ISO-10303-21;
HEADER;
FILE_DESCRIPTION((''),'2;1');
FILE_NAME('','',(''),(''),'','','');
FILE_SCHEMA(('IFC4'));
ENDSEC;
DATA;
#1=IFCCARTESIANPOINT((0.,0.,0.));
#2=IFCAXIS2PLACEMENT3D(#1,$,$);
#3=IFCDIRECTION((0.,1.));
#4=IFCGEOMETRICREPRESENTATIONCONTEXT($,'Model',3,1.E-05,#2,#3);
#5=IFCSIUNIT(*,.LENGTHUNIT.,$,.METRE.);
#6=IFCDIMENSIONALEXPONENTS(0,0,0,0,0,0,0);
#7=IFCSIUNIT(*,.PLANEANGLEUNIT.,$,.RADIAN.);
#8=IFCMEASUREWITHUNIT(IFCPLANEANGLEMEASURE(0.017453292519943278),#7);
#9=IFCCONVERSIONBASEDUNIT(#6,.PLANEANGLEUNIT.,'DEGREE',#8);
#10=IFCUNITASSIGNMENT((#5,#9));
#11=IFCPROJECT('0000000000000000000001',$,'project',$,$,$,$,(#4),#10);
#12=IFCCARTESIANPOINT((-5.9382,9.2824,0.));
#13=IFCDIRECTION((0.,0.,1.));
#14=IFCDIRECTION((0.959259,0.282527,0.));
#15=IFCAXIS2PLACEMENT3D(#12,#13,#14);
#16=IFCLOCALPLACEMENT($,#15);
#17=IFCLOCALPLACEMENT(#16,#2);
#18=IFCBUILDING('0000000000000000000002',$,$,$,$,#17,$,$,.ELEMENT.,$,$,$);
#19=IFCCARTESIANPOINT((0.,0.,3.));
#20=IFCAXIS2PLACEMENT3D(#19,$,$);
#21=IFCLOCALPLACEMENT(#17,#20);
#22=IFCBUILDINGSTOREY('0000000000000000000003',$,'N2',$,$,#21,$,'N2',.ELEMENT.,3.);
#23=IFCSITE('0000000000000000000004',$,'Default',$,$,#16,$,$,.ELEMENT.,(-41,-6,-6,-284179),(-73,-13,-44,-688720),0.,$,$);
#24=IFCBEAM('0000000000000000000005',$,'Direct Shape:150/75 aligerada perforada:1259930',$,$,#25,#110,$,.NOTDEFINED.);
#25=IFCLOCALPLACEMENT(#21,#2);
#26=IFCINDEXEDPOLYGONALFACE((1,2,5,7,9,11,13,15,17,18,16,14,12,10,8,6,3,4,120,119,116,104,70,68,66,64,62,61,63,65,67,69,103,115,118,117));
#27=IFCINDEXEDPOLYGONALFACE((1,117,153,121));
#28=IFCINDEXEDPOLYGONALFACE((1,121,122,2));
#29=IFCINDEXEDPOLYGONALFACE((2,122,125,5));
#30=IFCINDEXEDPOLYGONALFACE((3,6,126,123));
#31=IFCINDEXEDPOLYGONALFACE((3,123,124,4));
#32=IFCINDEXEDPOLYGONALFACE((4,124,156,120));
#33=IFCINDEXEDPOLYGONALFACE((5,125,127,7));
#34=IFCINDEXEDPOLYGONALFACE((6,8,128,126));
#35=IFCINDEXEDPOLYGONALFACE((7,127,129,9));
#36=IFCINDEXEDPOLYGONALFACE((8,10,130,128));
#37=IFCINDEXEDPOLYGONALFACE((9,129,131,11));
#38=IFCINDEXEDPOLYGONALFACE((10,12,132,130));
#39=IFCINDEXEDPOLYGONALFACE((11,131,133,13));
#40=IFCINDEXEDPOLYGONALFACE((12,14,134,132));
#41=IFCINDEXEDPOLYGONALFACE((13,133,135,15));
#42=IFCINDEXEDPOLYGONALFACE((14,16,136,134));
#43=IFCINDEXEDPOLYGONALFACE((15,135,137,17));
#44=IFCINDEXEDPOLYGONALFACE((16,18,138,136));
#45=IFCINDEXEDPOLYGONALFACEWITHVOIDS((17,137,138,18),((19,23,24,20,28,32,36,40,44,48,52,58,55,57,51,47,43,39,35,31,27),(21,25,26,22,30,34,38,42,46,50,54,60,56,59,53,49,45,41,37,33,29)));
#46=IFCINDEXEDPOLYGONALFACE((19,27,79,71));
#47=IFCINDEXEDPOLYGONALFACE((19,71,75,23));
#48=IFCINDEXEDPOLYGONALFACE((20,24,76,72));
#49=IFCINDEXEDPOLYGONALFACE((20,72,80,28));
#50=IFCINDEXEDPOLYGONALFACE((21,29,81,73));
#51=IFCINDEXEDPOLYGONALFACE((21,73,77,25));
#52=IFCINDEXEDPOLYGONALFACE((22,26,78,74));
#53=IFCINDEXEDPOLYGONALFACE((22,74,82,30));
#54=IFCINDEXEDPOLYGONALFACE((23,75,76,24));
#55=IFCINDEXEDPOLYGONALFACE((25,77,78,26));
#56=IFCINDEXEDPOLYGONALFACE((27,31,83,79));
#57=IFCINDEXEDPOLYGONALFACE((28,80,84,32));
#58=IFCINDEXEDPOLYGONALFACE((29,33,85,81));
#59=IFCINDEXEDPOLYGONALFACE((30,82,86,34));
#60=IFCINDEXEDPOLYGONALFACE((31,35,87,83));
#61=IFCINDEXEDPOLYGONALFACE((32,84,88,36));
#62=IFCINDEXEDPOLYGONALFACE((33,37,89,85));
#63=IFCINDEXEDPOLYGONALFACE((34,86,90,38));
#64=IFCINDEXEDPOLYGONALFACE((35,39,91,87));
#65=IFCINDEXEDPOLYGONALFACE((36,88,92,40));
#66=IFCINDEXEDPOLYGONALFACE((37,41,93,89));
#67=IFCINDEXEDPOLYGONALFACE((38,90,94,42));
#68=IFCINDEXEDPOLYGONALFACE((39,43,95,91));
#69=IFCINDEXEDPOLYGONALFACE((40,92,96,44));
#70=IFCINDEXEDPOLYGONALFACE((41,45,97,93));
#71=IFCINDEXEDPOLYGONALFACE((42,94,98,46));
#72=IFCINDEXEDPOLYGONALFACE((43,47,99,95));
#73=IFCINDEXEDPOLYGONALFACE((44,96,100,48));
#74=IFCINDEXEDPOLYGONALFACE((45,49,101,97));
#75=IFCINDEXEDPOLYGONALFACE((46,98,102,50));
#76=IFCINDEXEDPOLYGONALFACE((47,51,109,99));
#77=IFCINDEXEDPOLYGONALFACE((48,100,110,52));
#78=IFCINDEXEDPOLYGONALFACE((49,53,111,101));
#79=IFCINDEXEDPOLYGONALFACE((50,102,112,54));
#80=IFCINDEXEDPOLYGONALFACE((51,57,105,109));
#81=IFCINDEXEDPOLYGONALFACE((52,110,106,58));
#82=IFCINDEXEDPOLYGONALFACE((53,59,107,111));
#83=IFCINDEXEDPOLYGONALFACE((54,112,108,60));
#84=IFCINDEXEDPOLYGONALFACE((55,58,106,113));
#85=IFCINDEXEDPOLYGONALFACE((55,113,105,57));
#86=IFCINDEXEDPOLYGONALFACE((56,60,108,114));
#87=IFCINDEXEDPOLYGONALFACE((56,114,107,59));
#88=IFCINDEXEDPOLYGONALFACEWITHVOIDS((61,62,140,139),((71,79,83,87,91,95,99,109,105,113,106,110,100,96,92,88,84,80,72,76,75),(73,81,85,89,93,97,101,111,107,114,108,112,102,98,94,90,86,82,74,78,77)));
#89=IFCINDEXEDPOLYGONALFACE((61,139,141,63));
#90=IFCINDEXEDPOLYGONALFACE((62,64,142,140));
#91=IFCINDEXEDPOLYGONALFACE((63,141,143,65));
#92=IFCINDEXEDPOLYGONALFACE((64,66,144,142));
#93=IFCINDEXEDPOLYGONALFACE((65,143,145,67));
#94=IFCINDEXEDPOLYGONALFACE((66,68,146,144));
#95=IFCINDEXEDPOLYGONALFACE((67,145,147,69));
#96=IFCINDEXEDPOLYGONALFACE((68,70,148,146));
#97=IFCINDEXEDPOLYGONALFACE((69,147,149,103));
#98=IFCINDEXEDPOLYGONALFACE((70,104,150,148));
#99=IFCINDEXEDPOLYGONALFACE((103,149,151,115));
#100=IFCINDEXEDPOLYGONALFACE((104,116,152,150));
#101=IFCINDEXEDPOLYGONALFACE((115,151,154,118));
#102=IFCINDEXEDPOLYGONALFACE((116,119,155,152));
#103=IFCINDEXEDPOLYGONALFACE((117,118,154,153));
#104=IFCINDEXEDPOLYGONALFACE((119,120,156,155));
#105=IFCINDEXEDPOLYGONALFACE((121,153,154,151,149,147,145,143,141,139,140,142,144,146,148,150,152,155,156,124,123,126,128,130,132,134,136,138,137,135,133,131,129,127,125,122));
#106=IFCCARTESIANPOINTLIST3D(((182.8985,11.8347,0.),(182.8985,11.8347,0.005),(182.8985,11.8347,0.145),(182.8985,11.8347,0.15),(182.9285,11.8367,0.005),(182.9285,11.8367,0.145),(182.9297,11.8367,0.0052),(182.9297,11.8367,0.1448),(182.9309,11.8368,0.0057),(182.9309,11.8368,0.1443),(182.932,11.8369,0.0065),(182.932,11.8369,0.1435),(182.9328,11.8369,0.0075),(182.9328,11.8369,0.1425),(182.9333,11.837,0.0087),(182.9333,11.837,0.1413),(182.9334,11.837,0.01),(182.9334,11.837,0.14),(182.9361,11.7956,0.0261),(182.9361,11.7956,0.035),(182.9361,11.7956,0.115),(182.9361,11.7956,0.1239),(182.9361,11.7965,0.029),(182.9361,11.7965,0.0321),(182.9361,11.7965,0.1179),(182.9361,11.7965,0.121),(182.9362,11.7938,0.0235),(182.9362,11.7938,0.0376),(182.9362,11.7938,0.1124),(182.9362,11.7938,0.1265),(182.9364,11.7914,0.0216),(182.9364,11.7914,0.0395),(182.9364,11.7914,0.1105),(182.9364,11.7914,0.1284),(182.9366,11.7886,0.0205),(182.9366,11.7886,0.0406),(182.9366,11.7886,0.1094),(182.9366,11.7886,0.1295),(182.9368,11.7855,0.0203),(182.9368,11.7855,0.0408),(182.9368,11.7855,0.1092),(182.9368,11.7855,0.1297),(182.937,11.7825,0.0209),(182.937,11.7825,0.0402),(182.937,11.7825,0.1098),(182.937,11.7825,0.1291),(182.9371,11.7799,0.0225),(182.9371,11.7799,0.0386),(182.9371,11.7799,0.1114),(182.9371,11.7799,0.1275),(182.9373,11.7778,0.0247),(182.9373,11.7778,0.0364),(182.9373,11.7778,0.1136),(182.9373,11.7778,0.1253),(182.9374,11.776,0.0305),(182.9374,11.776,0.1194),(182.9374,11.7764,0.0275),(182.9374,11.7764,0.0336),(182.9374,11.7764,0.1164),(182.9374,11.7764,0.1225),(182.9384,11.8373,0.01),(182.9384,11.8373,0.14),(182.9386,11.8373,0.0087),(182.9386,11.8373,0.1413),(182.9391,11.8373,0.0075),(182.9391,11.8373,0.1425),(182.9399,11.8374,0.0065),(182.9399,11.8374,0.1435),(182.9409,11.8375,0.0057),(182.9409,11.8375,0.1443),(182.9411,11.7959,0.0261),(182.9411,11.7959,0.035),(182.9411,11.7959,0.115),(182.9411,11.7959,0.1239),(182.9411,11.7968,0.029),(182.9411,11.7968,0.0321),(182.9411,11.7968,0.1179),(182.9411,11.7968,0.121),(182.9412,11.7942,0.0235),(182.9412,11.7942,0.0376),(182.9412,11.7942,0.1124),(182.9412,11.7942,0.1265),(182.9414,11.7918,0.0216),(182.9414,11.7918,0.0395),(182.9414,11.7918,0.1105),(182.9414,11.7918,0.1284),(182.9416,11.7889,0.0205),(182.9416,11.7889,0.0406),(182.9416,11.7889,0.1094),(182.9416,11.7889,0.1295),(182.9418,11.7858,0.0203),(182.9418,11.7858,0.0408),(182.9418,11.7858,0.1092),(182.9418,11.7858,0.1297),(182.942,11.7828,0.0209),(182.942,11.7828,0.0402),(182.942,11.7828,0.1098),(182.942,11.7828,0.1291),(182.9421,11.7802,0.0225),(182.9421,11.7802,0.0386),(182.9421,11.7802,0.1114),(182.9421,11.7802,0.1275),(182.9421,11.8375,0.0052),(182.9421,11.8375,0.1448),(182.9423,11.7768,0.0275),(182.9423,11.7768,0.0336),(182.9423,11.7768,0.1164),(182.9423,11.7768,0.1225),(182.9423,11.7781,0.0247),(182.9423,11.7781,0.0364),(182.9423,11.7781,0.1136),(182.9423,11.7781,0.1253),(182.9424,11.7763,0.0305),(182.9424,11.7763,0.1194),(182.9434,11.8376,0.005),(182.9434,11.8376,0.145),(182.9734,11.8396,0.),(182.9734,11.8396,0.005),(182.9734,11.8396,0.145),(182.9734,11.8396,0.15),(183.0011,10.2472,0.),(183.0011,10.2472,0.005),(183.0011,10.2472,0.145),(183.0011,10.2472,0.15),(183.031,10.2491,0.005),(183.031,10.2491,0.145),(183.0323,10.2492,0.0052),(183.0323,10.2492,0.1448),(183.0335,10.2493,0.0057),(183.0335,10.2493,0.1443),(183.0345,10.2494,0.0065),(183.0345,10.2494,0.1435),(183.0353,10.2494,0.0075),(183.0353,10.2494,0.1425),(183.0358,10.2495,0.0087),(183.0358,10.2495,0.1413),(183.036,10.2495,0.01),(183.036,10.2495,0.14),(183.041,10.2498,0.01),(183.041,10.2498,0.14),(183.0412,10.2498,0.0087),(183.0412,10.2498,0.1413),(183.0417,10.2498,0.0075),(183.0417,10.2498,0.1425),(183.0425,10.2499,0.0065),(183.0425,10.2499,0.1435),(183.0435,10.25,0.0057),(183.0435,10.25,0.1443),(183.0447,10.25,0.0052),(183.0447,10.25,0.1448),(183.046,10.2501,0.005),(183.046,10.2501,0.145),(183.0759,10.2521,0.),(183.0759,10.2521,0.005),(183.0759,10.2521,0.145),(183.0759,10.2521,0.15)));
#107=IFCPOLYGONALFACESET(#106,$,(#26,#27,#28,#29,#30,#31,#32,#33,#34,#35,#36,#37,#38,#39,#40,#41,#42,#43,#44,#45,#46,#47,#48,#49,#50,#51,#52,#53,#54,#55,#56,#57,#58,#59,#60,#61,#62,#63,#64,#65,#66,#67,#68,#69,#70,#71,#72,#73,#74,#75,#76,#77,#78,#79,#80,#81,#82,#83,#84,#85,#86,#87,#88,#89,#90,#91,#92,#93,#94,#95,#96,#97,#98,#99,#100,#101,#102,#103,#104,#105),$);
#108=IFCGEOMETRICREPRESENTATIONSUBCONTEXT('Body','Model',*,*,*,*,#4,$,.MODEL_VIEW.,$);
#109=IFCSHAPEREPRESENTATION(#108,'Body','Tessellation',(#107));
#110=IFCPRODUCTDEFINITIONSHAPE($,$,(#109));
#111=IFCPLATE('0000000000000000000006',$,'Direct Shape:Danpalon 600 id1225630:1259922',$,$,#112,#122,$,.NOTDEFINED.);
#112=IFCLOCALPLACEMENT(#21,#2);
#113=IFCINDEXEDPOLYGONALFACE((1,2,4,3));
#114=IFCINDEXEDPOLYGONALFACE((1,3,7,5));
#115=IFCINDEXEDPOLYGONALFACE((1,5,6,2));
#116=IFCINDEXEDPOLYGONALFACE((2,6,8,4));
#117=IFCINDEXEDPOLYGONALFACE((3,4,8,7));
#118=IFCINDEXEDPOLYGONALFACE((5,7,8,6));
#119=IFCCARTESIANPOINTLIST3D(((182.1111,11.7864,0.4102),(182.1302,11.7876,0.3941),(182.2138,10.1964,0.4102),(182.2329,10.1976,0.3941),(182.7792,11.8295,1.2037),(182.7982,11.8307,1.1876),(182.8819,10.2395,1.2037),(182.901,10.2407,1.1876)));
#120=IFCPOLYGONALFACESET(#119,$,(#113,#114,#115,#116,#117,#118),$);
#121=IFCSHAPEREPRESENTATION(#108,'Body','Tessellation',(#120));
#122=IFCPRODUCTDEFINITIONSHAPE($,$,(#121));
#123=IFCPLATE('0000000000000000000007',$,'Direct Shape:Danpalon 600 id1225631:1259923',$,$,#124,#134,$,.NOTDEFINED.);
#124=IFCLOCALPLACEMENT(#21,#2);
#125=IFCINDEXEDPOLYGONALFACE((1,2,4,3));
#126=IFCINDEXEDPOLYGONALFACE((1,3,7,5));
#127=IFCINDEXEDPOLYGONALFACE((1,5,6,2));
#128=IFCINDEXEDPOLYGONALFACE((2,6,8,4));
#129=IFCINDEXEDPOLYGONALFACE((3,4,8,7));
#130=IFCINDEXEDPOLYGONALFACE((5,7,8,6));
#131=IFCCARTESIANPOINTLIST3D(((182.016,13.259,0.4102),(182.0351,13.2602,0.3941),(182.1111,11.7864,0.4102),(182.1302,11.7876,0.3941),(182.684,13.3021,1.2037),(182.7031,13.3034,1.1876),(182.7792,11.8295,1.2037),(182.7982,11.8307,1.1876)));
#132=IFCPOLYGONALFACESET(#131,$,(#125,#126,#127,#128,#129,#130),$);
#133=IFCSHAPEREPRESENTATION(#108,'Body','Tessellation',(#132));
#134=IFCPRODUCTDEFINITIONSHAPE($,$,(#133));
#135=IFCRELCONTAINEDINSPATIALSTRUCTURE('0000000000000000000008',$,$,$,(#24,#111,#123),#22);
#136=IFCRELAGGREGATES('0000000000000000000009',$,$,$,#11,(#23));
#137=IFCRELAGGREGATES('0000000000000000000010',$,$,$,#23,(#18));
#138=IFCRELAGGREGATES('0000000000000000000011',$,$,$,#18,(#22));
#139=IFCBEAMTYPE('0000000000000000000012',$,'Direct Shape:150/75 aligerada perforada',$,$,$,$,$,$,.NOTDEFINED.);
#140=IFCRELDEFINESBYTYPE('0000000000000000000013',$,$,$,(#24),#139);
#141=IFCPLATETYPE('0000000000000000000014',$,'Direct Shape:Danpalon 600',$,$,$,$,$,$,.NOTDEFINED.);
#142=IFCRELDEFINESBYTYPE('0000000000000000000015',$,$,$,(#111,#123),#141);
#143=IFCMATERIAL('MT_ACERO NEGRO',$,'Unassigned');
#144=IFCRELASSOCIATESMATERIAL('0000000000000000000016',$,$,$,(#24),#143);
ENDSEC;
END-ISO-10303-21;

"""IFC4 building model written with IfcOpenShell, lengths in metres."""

from ifc_helpers import new_model, entity, si_unit, converted_unit, direction, frame, frame_2d, origin, place, context, subcontext, project, spatial, rectangle, circle, i_section, extrude, material, type_object, element, save


model = new_model("IFC4")

# Units and contexts
model_context = context("Model", 3, precision=1e-05, world=origin(), true_north=direction((0.0, 1.0)))
body_context = subcontext(model_context, "Body", "Model", "MODEL_VIEW")
ifc_project = project(units=[si_unit("LENGTHUNIT", "METRE"), converted_unit("PLANEANGLEUNIT", "DEGREE", entity("IfcPlaneAngleMeasure", 0.017453292519943278), si_unit("PLANEANGLEUNIT", "RADIAN"), dimensions=[0, 0, 0, 0, 0, 0, 0])], contexts=[model_context])

# Site, building, storey
site_placement = place(None, frame((-5.9382, 9.2824, 0.0), z_axis=(0.0, 0.0, 1.0), x_axis=(0.959259, 0.282527, 0.0)))
site = spatial("IfcSite", under=ifc_project, at=site_placement, Name="Default", CompositionType="ELEMENT", RefLatitude=(-41, -6, -6, -284179), RefLongitude=(-73, -13, -44, -688720), RefElevation=0.0)
building_placement = place(site_placement, origin())
building = spatial("IfcBuilding", under=site, at=building_placement, CompositionType="ELEMENT")
storey_placement = place(building_placement, frame((0.0, 0.0, 3.0)))
storey = spatial("IfcBuildingStorey", under=building, at=storey_placement, Name="N2", LongName="N2", CompositionType="ELEMENT", Elevation=3.0)

# Beam, openings
ifc_material = material(Name="MT_ACERO NEGRO", Category="Unassigned")
beam_type = type_object("IfcBeamType", Name="Direct Shape:150/75 aligerada perforada", PredefinedType="NOTDEFINED")
beam_placement = place(storey_placement, origin())
beam = element("IfcBeam", 1, at=beam_placement, inside=storey, type_object=beam_type, material=ifc_material, Name="Direct Shape:150/75 aligerada perforada:1259930", PredefinedType="NOTDEFINED", context=body_context, shape_type="SweptSolid", body=[
    extrude(i_section(OverallWidth=0.075, OverallDepth=0.15, WebThickness=0.005, FlangeThickness=0.005, FilletRadius=0.005, at=frame_2d((0.0, 0.0), x_axis=(0.0, 1.0))), frame((183.0385, 10.2496, 0.075), z_axis=(-0.064471, 0.99792, 0.0), x_axis=(0.0, 0.0, 1.0)), (0.0, 0.0, 1.0), 1.5908),
])
opening_1_placement = place(storey_placement, origin())
element("IfcOpeningElement", 2, at=opening_1_placement, cuts=beam, PredefinedType="OPENING", context=body_context, shape_type="SweptSolid", body=[
    extrude(circle(Radius=0.0103, at=frame_2d((0.0, 0.0), x_axis=(1.0, 0.0))), frame((182.9417, 11.7866, 0.0305), z_axis=(-0.99792, -0.064471, 0.0), x_axis=(0.064471, -0.99792, 0.0)), (0.0, 0.0, 1.0), 0.005),
])
opening_2_placement = place(storey_placement, origin())
element("IfcOpeningElement", 3, at=opening_2_placement, cuts=beam, PredefinedType="OPENING", context=body_context, shape_type="SweptSolid", body=[
    extrude(circle(Radius=0.0103, at=frame_2d((0.0, 0.0), x_axis=(1.0, 0.0))), frame((182.9417, 11.7866, 0.1194), z_axis=(-0.99792, -0.064471, 0.0), x_axis=(0.064471, -0.99792, 0.0)), (0.0, 0.0, 1.0), 0.005),
])

# Plates
plate_type = type_object("IfcPlateType", Name="Direct Shape:Danpalon 600", PredefinedType="NOTDEFINED")
plate_1_placement = place(storey_placement, origin())
element("IfcPlate", 4, at=plate_1_placement, inside=storey, type_object=plate_type, Name="Direct Shape:Danpalon 600 id1225630:1259922", PredefinedType="NOTDEFINED", context=body_context, shape_type="SweptSolid", body=[
    extrude(rectangle(XDim=1.0381, YDim=0.025, at=frame_2d((0.0, 0.0), x_axis=(0.0, 1.0))), frame((182.5574, 10.2186, 0.7989), z_axis=(-0.064471, 0.99792, 0.0), x_axis=(-0.762714, -0.049276, 0.644857)), (0.0, 0.0, 1.0), 1.5933),
])
plate_2_placement = place(storey_placement, origin())
element("IfcPlate", 5, at=plate_2_placement, inside=storey, type_object=plate_type, Name="Direct Shape:Danpalon 600 id1225631:1259923", PredefinedType="NOTDEFINED", context=body_context, shape_type="SweptSolid", body=[
    extrude(rectangle(XDim=1.0381, YDim=0.025, at=frame_2d((0.0, 0.0), x_axis=(0.0, 1.0))), frame((182.4547, 11.8085, 0.7989), z_axis=(-0.064471, 0.99792, 0.0), x_axis=(-0.762714, -0.049276, 0.644857)), (0.0, 0.0, 1.0), 1.4757),
])

save(model, "model.ifc")
